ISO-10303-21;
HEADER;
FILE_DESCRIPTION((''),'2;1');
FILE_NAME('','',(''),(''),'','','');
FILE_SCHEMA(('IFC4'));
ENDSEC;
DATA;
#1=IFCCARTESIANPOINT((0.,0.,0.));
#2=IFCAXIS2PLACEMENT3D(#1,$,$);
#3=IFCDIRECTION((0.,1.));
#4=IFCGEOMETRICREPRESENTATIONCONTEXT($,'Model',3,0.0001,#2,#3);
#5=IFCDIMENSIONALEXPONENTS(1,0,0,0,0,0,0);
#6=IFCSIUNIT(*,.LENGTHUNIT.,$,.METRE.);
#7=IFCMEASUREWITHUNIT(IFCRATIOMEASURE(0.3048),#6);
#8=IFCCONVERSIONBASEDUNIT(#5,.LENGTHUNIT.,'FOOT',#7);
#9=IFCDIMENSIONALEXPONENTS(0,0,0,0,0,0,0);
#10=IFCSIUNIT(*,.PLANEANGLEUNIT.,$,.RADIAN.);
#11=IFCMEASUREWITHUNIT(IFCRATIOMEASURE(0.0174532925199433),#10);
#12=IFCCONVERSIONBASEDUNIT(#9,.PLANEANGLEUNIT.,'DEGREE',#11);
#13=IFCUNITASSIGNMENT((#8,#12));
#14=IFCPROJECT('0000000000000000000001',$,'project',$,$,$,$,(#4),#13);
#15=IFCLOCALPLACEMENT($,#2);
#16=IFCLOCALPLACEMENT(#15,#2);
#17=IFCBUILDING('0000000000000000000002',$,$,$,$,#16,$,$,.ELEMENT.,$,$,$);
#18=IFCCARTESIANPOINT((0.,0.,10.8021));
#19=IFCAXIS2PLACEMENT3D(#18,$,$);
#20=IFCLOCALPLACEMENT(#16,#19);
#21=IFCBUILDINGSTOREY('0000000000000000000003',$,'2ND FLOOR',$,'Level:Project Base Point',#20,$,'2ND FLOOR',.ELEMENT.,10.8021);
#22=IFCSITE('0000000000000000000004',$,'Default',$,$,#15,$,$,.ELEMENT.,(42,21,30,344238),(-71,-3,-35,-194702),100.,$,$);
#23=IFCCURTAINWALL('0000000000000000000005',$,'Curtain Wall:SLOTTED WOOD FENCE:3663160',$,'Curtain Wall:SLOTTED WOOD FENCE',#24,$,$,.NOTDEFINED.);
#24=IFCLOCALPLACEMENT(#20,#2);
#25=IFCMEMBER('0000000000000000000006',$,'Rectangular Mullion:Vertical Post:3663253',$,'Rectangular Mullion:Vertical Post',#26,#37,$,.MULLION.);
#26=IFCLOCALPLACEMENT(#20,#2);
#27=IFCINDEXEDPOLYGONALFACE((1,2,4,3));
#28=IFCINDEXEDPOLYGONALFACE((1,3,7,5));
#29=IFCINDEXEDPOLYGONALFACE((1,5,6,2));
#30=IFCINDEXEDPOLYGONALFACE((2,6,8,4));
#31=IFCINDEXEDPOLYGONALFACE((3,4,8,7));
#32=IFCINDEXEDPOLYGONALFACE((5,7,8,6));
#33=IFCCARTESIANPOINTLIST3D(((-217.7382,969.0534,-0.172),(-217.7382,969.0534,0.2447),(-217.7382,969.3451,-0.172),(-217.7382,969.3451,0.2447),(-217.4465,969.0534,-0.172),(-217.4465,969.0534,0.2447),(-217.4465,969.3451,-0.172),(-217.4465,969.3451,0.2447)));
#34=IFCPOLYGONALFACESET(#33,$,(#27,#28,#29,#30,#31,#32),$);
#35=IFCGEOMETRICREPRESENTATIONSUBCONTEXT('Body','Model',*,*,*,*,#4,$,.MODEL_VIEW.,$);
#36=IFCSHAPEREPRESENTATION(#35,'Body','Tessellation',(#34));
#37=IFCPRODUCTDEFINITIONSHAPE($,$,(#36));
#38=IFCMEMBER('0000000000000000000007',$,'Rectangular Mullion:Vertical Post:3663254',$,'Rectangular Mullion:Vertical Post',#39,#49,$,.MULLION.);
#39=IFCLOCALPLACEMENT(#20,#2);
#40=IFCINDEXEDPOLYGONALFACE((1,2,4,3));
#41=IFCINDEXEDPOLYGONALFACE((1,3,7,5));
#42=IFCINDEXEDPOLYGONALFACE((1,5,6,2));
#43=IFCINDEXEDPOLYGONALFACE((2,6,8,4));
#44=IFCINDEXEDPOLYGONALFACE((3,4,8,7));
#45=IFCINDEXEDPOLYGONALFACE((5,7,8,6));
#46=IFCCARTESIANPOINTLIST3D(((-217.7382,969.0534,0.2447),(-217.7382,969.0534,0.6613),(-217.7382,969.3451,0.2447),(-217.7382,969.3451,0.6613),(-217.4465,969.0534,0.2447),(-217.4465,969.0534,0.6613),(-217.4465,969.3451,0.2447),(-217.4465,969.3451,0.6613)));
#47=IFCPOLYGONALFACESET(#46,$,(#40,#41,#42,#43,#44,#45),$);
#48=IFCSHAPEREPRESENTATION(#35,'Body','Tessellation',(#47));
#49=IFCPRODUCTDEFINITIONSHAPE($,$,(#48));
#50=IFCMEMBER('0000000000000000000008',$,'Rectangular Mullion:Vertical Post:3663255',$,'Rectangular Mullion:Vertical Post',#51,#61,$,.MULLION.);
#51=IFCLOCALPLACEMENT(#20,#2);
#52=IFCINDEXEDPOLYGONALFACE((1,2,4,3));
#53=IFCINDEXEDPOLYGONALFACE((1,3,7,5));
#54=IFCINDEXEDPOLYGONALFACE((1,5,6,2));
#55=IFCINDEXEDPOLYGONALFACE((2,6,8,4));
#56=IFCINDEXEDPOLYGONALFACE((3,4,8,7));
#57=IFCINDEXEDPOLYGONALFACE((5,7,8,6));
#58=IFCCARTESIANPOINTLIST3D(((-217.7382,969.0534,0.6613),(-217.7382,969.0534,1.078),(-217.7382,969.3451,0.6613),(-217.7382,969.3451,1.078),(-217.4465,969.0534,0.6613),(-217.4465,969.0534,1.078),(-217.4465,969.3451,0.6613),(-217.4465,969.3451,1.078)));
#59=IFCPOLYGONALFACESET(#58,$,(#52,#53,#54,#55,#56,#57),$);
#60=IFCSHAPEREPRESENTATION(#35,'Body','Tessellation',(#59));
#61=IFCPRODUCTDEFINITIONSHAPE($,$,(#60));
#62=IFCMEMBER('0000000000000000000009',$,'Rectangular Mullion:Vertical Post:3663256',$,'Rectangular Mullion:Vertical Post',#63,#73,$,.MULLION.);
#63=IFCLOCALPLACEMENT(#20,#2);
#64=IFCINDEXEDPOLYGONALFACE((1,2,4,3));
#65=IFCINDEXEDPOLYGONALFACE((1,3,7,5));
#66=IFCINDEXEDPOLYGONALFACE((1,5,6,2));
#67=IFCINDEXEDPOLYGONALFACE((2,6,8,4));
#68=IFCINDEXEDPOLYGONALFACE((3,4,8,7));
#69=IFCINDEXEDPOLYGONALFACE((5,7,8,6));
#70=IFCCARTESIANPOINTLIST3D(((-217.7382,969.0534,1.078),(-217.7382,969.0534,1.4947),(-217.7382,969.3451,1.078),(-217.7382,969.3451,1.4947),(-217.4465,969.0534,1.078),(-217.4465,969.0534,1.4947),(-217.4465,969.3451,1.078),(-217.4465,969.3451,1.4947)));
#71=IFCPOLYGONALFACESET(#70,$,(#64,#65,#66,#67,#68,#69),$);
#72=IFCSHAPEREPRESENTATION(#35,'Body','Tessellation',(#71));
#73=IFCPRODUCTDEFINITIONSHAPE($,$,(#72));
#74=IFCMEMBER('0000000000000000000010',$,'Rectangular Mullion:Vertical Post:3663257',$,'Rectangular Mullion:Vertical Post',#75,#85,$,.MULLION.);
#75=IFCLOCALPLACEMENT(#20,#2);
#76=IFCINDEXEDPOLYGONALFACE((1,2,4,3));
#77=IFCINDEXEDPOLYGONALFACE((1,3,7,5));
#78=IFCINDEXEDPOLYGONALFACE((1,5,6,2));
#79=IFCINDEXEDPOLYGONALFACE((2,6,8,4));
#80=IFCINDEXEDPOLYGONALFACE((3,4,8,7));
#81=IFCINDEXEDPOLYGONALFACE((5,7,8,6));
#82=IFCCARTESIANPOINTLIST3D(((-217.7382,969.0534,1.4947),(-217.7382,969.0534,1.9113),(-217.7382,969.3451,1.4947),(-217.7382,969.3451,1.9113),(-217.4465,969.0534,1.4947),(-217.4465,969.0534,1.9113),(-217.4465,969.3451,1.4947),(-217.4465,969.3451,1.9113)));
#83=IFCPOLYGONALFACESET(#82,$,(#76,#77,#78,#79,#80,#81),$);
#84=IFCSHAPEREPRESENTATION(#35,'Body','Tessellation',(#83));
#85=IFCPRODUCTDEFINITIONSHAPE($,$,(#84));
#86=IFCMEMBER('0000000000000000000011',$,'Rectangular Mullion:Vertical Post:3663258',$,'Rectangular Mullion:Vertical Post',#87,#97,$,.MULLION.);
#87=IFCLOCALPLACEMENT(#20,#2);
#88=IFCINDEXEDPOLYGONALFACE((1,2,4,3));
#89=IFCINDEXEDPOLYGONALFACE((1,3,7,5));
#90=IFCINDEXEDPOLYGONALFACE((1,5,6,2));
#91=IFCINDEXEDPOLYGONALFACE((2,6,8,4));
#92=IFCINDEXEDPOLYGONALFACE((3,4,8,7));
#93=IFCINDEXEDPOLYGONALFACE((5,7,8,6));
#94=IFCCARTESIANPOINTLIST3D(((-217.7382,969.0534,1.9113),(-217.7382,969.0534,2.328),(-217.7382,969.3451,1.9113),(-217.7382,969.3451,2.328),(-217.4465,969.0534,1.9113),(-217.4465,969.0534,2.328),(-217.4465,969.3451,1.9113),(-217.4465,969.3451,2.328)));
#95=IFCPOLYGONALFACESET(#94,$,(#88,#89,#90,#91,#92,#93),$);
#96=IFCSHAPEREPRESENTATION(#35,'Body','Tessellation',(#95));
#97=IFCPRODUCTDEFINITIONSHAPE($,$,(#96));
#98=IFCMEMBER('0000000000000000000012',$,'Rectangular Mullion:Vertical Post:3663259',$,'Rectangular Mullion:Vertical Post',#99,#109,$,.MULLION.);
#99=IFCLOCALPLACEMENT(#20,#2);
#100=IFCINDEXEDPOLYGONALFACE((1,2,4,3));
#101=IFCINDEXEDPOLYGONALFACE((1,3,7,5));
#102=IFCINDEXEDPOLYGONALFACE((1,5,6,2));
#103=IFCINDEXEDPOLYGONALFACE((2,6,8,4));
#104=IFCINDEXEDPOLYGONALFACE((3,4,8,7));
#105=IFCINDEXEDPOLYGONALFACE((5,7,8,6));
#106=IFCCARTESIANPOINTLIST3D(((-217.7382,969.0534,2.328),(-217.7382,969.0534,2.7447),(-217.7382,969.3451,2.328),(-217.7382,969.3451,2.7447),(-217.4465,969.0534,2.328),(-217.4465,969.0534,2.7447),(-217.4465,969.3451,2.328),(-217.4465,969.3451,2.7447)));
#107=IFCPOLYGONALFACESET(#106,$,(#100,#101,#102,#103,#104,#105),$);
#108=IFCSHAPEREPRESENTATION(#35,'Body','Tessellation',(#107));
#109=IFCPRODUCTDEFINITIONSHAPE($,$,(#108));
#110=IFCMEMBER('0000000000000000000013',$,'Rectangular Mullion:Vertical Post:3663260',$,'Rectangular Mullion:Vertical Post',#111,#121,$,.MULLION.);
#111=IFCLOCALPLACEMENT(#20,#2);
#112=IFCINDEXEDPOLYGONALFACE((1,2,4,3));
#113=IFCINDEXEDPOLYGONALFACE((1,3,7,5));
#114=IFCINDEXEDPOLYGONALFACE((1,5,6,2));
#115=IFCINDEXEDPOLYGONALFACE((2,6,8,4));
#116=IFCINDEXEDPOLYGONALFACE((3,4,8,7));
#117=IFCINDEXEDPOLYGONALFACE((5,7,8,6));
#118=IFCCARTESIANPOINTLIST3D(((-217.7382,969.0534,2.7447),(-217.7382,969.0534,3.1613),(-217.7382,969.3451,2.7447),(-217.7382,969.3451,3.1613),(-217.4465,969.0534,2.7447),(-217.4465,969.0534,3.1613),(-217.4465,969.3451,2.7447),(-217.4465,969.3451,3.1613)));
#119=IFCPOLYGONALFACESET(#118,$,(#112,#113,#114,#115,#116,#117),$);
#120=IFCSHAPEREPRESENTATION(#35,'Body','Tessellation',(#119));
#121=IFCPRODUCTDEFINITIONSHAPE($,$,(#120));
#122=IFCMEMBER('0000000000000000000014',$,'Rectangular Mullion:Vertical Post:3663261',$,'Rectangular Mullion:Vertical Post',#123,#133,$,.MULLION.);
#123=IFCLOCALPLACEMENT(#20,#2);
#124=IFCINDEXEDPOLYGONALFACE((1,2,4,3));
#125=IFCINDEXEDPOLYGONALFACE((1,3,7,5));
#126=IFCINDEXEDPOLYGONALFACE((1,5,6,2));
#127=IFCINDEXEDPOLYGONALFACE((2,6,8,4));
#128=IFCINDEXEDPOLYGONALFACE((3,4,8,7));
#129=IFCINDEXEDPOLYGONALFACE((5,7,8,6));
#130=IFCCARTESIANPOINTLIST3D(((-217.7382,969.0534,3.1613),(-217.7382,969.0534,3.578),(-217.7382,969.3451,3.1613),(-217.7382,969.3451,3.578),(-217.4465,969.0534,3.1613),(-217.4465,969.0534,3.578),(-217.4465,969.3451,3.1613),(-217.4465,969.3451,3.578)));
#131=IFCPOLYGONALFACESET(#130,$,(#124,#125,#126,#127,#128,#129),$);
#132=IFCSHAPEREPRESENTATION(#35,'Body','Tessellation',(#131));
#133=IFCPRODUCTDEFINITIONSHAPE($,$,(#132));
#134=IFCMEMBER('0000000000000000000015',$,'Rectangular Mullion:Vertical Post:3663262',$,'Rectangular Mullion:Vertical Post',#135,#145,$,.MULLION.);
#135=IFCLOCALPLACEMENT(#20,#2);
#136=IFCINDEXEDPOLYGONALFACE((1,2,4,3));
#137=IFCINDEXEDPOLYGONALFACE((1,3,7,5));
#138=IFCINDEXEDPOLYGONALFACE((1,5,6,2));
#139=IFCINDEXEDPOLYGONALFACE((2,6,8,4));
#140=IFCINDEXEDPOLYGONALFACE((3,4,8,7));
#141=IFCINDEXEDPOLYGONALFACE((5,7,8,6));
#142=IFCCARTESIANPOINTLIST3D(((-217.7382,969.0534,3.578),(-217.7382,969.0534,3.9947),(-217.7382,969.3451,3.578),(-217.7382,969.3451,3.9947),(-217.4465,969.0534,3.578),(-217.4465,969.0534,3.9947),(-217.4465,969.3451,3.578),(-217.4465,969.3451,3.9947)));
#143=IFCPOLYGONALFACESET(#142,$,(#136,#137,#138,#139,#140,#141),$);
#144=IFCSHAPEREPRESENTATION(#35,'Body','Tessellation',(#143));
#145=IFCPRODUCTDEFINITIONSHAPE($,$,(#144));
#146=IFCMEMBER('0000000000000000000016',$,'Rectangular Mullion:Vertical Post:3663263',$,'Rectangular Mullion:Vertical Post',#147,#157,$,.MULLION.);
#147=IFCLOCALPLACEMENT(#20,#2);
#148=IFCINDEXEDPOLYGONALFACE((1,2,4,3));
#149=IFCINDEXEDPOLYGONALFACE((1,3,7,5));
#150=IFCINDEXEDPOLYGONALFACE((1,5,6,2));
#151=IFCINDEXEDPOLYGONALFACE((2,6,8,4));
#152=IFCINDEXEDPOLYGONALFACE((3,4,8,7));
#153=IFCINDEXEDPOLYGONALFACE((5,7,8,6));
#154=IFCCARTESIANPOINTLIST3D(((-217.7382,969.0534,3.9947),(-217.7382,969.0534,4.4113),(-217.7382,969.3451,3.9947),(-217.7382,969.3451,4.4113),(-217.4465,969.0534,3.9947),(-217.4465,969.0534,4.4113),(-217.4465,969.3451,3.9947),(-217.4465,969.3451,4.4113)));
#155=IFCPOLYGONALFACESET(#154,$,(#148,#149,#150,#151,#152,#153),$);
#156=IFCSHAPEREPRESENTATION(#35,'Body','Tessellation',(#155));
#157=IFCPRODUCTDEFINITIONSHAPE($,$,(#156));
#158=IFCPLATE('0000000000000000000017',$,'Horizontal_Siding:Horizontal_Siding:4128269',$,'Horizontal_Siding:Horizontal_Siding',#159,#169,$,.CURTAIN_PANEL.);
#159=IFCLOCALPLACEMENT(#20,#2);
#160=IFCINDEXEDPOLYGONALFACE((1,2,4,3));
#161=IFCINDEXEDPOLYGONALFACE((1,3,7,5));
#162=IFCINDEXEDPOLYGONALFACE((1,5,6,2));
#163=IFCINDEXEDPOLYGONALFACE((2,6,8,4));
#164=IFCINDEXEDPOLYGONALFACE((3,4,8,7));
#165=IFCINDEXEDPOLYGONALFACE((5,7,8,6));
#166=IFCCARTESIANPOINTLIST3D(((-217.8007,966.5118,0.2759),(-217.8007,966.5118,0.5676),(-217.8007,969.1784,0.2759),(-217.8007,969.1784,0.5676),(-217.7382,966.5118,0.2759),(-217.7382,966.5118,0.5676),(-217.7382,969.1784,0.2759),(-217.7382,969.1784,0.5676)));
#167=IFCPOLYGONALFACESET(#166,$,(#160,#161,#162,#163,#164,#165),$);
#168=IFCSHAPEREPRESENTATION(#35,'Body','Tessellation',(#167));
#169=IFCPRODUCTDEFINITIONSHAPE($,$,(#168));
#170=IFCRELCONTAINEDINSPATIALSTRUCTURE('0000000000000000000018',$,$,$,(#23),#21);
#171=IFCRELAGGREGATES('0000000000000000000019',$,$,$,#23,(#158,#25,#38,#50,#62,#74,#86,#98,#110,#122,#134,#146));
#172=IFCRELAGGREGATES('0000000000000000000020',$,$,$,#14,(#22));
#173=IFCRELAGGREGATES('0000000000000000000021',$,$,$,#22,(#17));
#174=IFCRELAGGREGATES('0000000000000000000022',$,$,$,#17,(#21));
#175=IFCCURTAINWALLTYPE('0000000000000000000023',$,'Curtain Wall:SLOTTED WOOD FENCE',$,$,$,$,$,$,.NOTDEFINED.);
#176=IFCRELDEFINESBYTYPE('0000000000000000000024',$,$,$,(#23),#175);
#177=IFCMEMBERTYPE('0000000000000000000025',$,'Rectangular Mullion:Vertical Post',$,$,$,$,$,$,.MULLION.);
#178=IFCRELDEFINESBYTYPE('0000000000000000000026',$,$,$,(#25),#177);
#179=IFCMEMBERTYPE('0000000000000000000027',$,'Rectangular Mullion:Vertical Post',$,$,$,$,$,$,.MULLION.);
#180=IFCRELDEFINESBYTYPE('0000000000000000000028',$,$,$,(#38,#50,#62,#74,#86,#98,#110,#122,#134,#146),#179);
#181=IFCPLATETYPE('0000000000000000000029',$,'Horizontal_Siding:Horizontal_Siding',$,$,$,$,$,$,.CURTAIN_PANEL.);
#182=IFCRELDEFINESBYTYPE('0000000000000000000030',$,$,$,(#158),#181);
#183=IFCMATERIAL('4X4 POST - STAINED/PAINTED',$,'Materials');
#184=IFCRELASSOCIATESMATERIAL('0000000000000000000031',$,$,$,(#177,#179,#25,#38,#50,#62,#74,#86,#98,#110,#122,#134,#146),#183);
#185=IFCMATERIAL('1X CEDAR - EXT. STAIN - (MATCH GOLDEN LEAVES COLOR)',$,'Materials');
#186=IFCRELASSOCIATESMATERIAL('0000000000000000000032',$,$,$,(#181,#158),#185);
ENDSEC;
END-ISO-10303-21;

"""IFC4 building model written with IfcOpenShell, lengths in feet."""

from ifc_helpers import new_model, entity, si_unit, converted_unit, direction, frame, origin, origin_2d_with_axis, place, context, subcontext, project, spatial, rectangle, extrude, source, transform, mapped, material, material_profile, profile_set, profile_usage, type_object, type_shapes, element, aggregate, save


model = new_model("IFC4")

# Units and contexts
model_context = context("Model", 3, precision=0.0001, world=origin(), true_north=direction((0.0, 1.0)))
body_context = subcontext(model_context, "Body", "Model", "MODEL_VIEW")
ifc_project = project(units=[converted_unit("LENGTHUNIT", "FOOT", entity("IfcRatioMeasure", 0.3048), si_unit("LENGTHUNIT", "METRE"), dimensions=[1, 0, 0, 0, 0, 0, 0]), converted_unit("PLANEANGLEUNIT", "DEGREE", entity("IfcRatioMeasure", 0.0174532925199433), si_unit("PLANEANGLEUNIT", "RADIAN"), dimensions=[0, 0, 0, 0, 0, 0, 0])], contexts=[model_context])

# Site, building, storey
site_placement = place(None, origin())
site = spatial("IfcSite", under=ifc_project, at=site_placement, Name="Default", CompositionType="ELEMENT", RefLatitude=(42, 21, 30, 344238), RefLongitude=(-71, -3, -35, -194702), RefElevation=100.0)
building_placement = place(site_placement, origin())
building = spatial("IfcBuilding", under=site, at=building_placement, CompositionType="ELEMENT")
storey_placement = place(building_placement, frame((0.0, 0.0, 10.8021)))
storey = spatial("IfcBuildingStorey", under=building, at=storey_placement, Name="2ND FLOOR", ObjectType="Level:Project Base Point", LongName="2ND FLOOR", CompositionType="ELEMENT", Elevation=10.8021)

# Curtain wall, members, plate
curtain_wall_type = type_object("IfcCurtainWallType", Name="Curtain Wall:SLOTTED WOOD FENCE", PredefinedType="NOTDEFINED")
curtain_wall_placement = place(storey_placement, frame((0.0, 0.0, -10.8021)))
curtain_wall = element("IfcCurtainWall", 1, at=curtain_wall_placement, inside=storey, type_object=curtain_wall_type, Name="Curtain Wall:SLOTTED WOOD FENCE:3663160", ObjectType="Curtain Wall:SLOTTED WOOD FENCE", PredefinedType="NOTDEFINED")
ifc_material_1 = material(Name="4X4 POST - STAINED/PAINTED", Category="Materials")
ifc_material_profile = material_profile(ifc_material_1, rectangle(XDim=0.2917, YDim=0.2917, at=origin_2d_with_axis()), Name="Vertical Post")
ifc_profile_set = profile_set([ifc_material_profile], Name="Vertical Post")
ifc_profile_usage_1 = profile_usage(ifc_profile_set)
member_type_1 = type_object("IfcMemberType", Name="Rectangular Mullion:Vertical Post", PredefinedType="MULLION", material=ifc_profile_set)
shared_shape_1 = source(origin(), body_context, "Body", "SweptSolid", [
    extrude(rectangle(XDim=0.2917, YDim=0.2917, at=origin_2d_with_axis()), frame((-0.1458, -0.2083, -0.4167), z_axis=(0.0, 0.0, 1.0), x_axis=(0.0, -1.0, 0.0)), (0.0, 0.0, 1.0), 0.4167),
])
type_shapes(member_type_1, [shared_shape_1])
member_1_placement = place(storey_placement, frame((-217.8007, 969.3451, 0.2447), z_axis=(0.0, 0.0, 1.0), x_axis=(0.0, 1.0, 0.0)))
member_1 = element("IfcMember", 2, at=member_1_placement, type_object=member_type_1, material=ifc_profile_usage_1, Name="Rectangular Mullion:Vertical Post:3663253", ObjectType="Rectangular Mullion:Vertical Post", PredefinedType="MULLION", context=body_context, shape_type="MappedRepresentation", body=[
    mapped(shared_shape_1, transform((0.0, 0.0, 0.0), scale=1.0)),
])
ifc_profile_usage_2 = profile_usage(ifc_profile_set)
member_type_2 = type_object("IfcMemberType", Name="Rectangular Mullion:Vertical Post", PredefinedType="MULLION", material=ifc_profile_set)
shared_shape_2 = source(origin(), body_context, "Body", "SweptSolid", [
    extrude(rectangle(XDim=0.2917, YDim=0.2917, at=origin_2d_with_axis()), frame((-0.1458, -0.2083, -0.4167), z_axis=(0.0, 0.0, 1.0), x_axis=(0.0, -1.0, 0.0)), (0.0, 0.0, 1.0), 0.4167),
])
type_shapes(member_type_2, [shared_shape_2])
member_2_placement = place(storey_placement, frame((-217.8007, 969.3451, 0.6613), z_axis=(0.0, 0.0, 1.0), x_axis=(0.0, 1.0, 0.0)))
member_2 = element("IfcMember", 3, at=member_2_placement, type_object=member_type_2, material=ifc_profile_usage_2, Name="Rectangular Mullion:Vertical Post:3663254", ObjectType="Rectangular Mullion:Vertical Post", PredefinedType="MULLION", context=body_context, shape_type="MappedRepresentation", body=[
    mapped(shared_shape_2, transform((0.0, 0.0, 0.0), scale=1.0)),
])
ifc_profile_usage_3 = profile_usage(ifc_profile_set)
member_3_placement = place(storey_placement, frame((-217.8007, 969.3451, 1.078), z_axis=(0.0, 0.0, 1.0), x_axis=(0.0, 1.0, 0.0)))
member_3 = element("IfcMember", 4, at=member_3_placement, type_object=member_type_2, material=ifc_profile_usage_3, Name="Rectangular Mullion:Vertical Post:3663255", ObjectType="Rectangular Mullion:Vertical Post", PredefinedType="MULLION", context=body_context, shape_type="MappedRepresentation", body=[
    mapped(shared_shape_2, transform((0.0, 0.0, 0.0), scale=1.0)),
])
ifc_profile_usage_4 = profile_usage(ifc_profile_set)
member_4_placement = place(storey_placement, frame((-217.8007, 969.3451, 1.4947), z_axis=(0.0, 0.0, 1.0), x_axis=(0.0, 1.0, 0.0)))
member_4 = element("IfcMember", 5, at=member_4_placement, type_object=member_type_2, material=ifc_profile_usage_4, Name="Rectangular Mullion:Vertical Post:3663256", ObjectType="Rectangular Mullion:Vertical Post", PredefinedType="MULLION", context=body_context, shape_type="MappedRepresentation", body=[
    mapped(shared_shape_2, transform((0.0, 0.0, 0.0), scale=1.0)),
])
ifc_profile_usage_5 = profile_usage(ifc_profile_set)
member_5_placement = place(storey_placement, frame((-217.8007, 969.3451, 1.9113), z_axis=(0.0, 0.0, 1.0), x_axis=(0.0, 1.0, 0.0)))
member_5 = element("IfcMember", 6, at=member_5_placement, type_object=member_type_2, material=ifc_profile_usage_5, Name="Rectangular Mullion:Vertical Post:3663257", ObjectType="Rectangular Mullion:Vertical Post", PredefinedType="MULLION", context=body_context, shape_type="MappedRepresentation", body=[
    mapped(shared_shape_2, transform((0.0, 0.0, 0.0), scale=1.0)),
])
ifc_profile_usage_6 = profile_usage(ifc_profile_set)
member_6_placement = place(storey_placement, frame((-217.8007, 969.3451, 2.328), z_axis=(0.0, 0.0, 1.0), x_axis=(0.0, 1.0, 0.0)))
member_6 = element("IfcMember", 7, at=member_6_placement, type_object=member_type_2, material=ifc_profile_usage_6, Name="Rectangular Mullion:Vertical Post:3663258", ObjectType="Rectangular Mullion:Vertical Post", PredefinedType="MULLION", context=body_context, shape_type="MappedRepresentation", body=[
    mapped(shared_shape_2, transform((0.0, 0.0, 0.0), scale=1.0)),
])
ifc_profile_usage_7 = profile_usage(ifc_profile_set)
member_7_placement = place(storey_placement, frame((-217.8007, 969.3451, 2.7447), z_axis=(0.0, 0.0, 1.0), x_axis=(0.0, 1.0, 0.0)))
member_7 = element("IfcMember", 8, at=member_7_placement, type_object=member_type_2, material=ifc_profile_usage_7, Name="Rectangular Mullion:Vertical Post:3663259", ObjectType="Rectangular Mullion:Vertical Post", PredefinedType="MULLION", context=body_context, shape_type="MappedRepresentation", body=[
    mapped(shared_shape_2, transform((0.0, 0.0, 0.0), scale=1.0)),
])
ifc_profile_usage_8 = profile_usage(ifc_profile_set)
member_8_placement = place(storey_placement, frame((-217.8007, 969.3451, 3.1613), z_axis=(0.0, 0.0, 1.0), x_axis=(0.0, 1.0, 0.0)))
member_8 = element("IfcMember", 9, at=member_8_placement, type_object=member_type_2, material=ifc_profile_usage_8, Name="Rectangular Mullion:Vertical Post:3663260", ObjectType="Rectangular Mullion:Vertical Post", PredefinedType="MULLION", context=body_context, shape_type="MappedRepresentation", body=[
    mapped(shared_shape_2, transform((0.0, 0.0, 0.0), scale=1.0)),
])
ifc_profile_usage_9 = profile_usage(ifc_profile_set)
member_9_placement = place(storey_placement, frame((-217.8007, 969.3451, 3.578), z_axis=(0.0, 0.0, 1.0), x_axis=(0.0, 1.0, 0.0)))
member_9 = element("IfcMember", 10, at=member_9_placement, type_object=member_type_2, material=ifc_profile_usage_9, Name="Rectangular Mullion:Vertical Post:3663261", ObjectType="Rectangular Mullion:Vertical Post", PredefinedType="MULLION", context=body_context, shape_type="MappedRepresentation", body=[
    mapped(shared_shape_2, transform((0.0, 0.0, 0.0), scale=1.0)),
])
ifc_profile_usage_10 = profile_usage(ifc_profile_set)
member_10_placement = place(storey_placement, frame((-217.8007, 969.3451, 3.9947), z_axis=(0.0, 0.0, 1.0), x_axis=(0.0, 1.0, 0.0)))
member_10 = element("IfcMember", 11, at=member_10_placement, type_object=member_type_2, material=ifc_profile_usage_10, Name="Rectangular Mullion:Vertical Post:3663262", ObjectType="Rectangular Mullion:Vertical Post", PredefinedType="MULLION", context=body_context, shape_type="MappedRepresentation", body=[
    mapped(shared_shape_2, transform((0.0, 0.0, 0.0), scale=1.0)),
])
ifc_profile_usage_11 = profile_usage(ifc_profile_set)
member_11_placement = place(storey_placement, frame((-217.8007, 969.3451, 4.4113), z_axis=(0.0, 0.0, 1.0), x_axis=(0.0, 1.0, 0.0)))
member_11 = element("IfcMember", 12, at=member_11_placement, type_object=member_type_2, material=ifc_profile_usage_11, Name="Rectangular Mullion:Vertical Post:3663263", ObjectType="Rectangular Mullion:Vertical Post", PredefinedType="MULLION", context=body_context, shape_type="MappedRepresentation", body=[
    mapped(shared_shape_2, transform((0.0, 0.0, 0.0), scale=1.0)),
])
ifc_material_2 = material(Name="1X CEDAR - EXT. STAIN - (MATCH GOLDEN LEAVES COLOR)", Category="Materials")
plate_type = type_object("IfcPlateType", Name="Horizontal_Siding:Horizontal_Siding", PredefinedType="CURTAIN_PANEL", material=ifc_material_2)
shared_shape_3 = source(origin(), body_context, "Body", "SweptSolid", [
    extrude(rectangle(XDim=2.6667, YDim=0.0625, at=origin_2d_with_axis()), frame((1.3333, 0.0312, 0.0), z_axis=(0.0, 0.0, 1.0), x_axis=(-1.0, 0.0, 0.0)), (0.0, 0.0, 1.0), 0.2917),
])
type_shapes(plate_type, [shared_shape_3])
plate_1_placement = place(curtain_wall_placement, frame((-217.8007, 969.1784, 11.078), z_axis=(0.0, 0.0, 1.0), x_axis=(0.0, -1.0, 0.0)))
plate_1 = element("IfcPlate", 13, at=plate_1_placement, type_object=plate_type, material=ifc_material_2, Name="Horizontal_Siding:Horizontal_Siding:4128269", ObjectType="Horizontal_Siding:Horizontal_Siding", PredefinedType="CURTAIN_PANEL", context=body_context, shape_type="MappedRepresentation", body=[
    mapped(shared_shape_3, transform((0.0, 0.0, 0.0), scale=1.0)),
])
aggregate(curtain_wall, [plate_1, member_1, member_2, member_3, member_4, member_5, member_6, member_7, member_8, member_9, member_10, member_11])

save(model, "model.ifc")
